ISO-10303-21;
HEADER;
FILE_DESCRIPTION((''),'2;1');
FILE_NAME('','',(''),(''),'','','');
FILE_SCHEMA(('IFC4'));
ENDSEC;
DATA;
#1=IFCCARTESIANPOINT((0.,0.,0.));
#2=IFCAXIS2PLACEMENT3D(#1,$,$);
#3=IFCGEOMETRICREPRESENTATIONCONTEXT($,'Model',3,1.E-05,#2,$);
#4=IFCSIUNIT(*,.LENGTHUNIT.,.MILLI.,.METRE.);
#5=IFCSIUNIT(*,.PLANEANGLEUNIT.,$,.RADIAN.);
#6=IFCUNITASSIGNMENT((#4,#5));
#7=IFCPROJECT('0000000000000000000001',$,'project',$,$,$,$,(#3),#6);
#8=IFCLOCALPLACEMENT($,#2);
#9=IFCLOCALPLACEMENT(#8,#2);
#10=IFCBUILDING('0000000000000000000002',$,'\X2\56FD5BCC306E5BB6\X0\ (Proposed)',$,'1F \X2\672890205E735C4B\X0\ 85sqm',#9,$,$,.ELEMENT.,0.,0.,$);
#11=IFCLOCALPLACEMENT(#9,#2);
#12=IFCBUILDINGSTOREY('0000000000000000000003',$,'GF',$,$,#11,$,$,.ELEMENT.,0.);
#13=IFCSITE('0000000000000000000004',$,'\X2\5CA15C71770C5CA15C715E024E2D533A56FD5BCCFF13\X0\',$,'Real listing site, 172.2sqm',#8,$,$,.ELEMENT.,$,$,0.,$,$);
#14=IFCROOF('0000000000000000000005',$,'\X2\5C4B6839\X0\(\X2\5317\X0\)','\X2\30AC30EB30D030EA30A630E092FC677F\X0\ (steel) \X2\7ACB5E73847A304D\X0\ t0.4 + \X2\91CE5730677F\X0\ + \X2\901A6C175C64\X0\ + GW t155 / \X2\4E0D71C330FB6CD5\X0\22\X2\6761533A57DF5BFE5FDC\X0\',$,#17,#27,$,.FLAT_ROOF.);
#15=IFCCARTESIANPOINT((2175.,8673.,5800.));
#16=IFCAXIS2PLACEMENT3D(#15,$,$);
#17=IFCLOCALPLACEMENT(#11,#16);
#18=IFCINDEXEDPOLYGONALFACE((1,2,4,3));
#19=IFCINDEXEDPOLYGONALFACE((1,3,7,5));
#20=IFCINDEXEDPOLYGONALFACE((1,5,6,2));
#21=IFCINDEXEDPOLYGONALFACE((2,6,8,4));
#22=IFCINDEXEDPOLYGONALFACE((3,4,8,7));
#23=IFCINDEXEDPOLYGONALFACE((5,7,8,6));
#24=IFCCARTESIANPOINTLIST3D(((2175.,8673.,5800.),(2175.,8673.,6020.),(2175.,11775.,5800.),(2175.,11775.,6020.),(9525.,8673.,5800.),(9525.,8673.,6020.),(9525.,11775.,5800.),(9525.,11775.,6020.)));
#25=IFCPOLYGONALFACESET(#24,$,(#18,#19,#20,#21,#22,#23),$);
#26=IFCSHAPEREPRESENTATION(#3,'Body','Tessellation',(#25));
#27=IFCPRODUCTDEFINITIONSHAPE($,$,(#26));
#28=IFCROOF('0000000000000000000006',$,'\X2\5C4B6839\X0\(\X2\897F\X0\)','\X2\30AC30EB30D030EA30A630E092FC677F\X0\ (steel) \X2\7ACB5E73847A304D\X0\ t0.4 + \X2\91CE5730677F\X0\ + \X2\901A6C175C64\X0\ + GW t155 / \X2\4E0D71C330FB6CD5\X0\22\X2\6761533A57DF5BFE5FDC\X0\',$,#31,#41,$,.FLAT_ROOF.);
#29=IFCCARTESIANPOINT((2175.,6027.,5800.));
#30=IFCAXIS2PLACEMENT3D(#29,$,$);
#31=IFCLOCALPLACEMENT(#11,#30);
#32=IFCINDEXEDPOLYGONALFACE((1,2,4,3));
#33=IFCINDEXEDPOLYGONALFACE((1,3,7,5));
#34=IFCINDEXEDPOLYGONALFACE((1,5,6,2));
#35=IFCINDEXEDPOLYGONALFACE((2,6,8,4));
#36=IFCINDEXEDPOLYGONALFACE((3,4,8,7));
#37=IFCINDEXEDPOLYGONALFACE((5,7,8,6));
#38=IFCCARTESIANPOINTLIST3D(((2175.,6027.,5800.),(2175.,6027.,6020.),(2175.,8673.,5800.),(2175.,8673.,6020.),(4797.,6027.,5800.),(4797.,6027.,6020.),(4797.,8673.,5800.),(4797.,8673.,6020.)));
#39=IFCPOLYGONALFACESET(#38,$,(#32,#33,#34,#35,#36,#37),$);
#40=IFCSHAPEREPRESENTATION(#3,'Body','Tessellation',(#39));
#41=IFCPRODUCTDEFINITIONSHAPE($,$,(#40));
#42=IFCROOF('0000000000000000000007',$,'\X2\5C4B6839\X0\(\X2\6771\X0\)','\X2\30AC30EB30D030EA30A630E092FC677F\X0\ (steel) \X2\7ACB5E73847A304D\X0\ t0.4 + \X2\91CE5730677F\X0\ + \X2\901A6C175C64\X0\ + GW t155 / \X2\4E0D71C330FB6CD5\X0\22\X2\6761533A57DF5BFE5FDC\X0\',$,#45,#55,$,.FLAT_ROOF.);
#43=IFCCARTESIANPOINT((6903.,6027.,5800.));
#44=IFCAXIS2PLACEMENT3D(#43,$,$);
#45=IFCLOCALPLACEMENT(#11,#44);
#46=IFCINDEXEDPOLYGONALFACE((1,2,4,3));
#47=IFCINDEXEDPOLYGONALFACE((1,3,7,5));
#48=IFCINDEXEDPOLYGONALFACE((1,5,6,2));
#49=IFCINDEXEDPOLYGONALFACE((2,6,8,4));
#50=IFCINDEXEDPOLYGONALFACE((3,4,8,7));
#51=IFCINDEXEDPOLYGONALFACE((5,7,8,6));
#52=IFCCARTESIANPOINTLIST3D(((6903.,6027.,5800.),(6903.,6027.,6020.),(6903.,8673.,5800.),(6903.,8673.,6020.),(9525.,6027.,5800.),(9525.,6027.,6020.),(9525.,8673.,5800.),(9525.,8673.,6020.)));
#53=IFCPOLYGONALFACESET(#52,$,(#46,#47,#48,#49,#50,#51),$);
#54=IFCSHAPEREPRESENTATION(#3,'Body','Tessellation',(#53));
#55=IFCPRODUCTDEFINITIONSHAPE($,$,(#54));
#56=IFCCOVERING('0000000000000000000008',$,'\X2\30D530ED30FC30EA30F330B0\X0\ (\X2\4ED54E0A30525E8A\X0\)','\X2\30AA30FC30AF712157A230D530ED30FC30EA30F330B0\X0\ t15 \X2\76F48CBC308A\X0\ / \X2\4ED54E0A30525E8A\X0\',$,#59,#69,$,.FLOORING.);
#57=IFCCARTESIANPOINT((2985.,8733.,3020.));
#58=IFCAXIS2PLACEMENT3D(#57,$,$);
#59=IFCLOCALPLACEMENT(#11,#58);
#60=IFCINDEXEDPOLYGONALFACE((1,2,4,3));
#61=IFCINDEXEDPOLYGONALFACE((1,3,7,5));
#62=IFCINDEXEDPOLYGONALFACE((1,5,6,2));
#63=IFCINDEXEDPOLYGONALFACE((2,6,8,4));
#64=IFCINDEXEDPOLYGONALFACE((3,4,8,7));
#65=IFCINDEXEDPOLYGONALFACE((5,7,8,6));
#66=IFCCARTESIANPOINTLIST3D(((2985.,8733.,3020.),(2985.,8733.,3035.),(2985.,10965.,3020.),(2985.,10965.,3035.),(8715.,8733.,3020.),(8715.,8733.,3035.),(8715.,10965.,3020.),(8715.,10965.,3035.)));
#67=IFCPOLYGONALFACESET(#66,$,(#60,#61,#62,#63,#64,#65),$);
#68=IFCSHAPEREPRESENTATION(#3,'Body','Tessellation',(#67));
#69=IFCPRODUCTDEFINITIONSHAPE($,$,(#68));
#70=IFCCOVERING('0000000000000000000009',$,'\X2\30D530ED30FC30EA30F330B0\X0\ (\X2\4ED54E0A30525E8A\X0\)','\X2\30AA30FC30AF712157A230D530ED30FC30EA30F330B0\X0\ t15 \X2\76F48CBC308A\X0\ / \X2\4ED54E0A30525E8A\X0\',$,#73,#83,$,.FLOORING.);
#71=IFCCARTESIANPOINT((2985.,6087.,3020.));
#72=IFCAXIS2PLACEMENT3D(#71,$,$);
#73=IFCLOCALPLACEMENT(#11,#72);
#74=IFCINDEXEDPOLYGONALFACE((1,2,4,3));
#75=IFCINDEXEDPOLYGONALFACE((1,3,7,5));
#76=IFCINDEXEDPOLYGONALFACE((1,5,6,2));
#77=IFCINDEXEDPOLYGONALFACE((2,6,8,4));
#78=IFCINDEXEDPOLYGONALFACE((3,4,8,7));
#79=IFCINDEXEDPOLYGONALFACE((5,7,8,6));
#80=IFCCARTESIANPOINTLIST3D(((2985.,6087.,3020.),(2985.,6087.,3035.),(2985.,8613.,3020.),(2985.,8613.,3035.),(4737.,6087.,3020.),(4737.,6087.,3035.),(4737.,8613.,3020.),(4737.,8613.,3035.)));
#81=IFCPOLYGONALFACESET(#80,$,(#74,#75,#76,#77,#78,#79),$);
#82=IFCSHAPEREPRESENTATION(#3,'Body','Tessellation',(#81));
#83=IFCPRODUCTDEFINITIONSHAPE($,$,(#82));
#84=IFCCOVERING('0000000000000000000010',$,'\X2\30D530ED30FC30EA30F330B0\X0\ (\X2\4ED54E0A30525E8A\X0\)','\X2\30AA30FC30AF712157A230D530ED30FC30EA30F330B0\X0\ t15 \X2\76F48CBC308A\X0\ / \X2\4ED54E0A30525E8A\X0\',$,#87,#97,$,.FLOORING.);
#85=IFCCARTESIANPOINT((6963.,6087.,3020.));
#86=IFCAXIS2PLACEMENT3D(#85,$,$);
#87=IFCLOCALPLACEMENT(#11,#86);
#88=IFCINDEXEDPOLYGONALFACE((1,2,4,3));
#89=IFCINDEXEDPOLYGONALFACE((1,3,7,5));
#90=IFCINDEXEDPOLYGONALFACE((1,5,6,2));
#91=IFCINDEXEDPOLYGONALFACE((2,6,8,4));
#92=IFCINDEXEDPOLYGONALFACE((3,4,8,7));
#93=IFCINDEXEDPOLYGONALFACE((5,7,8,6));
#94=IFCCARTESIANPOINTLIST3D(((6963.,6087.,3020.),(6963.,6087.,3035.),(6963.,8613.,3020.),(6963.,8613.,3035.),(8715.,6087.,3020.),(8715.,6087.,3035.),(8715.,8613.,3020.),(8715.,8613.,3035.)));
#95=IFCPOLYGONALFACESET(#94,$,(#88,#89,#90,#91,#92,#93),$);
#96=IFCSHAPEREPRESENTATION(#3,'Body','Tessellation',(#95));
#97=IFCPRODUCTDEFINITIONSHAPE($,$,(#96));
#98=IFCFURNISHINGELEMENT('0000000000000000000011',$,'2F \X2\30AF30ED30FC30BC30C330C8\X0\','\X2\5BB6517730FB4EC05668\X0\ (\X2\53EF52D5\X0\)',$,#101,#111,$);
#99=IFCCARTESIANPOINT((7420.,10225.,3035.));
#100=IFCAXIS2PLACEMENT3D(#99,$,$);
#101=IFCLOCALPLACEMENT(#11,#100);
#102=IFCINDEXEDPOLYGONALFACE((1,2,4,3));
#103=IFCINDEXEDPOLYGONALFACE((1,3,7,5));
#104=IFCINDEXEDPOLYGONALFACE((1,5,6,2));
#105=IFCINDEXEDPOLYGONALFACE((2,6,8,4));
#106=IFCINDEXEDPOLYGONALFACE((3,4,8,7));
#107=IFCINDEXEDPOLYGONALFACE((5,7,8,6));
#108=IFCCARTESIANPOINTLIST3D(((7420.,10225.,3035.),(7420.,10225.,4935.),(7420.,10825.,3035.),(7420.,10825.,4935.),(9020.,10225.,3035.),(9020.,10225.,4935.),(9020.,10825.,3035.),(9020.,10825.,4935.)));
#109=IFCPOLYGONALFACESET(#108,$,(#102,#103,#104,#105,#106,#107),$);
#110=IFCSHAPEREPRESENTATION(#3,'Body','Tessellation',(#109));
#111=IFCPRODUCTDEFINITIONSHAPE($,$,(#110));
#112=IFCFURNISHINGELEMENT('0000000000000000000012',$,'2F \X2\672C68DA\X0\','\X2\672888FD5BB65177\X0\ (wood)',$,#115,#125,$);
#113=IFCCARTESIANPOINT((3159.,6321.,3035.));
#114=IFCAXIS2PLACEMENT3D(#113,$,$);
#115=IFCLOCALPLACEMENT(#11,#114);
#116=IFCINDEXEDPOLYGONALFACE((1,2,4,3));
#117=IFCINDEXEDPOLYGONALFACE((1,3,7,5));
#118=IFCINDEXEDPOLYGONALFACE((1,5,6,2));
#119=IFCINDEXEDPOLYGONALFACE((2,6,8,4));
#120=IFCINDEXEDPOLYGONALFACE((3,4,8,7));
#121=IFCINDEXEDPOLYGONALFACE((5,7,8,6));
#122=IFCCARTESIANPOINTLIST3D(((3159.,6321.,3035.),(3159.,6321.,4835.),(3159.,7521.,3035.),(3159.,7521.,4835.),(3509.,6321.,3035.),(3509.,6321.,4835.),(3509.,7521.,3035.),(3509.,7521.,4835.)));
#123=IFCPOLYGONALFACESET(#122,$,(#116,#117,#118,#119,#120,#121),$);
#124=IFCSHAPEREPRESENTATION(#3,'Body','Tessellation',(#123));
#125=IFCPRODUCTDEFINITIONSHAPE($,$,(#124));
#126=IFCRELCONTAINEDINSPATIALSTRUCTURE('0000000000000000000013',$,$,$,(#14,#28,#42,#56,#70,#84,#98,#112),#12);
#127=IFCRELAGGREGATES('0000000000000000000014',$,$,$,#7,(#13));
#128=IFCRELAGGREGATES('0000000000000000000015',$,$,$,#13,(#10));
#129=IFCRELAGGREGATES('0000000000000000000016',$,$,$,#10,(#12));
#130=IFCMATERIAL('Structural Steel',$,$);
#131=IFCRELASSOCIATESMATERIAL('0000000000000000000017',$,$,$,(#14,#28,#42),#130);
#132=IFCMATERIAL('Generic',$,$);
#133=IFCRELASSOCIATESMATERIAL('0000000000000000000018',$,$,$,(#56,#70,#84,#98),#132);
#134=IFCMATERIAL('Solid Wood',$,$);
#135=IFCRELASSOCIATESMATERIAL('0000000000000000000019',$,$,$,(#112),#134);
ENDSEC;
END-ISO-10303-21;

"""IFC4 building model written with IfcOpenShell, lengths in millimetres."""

from ifc_helpers import new_model, si_unit, frame, frame_2d, origin, place, context, project, spatial, rectangle, extrude, material, element, save


model = new_model("IFC4")

# Units and contexts
model_context = context("Model", 3, precision=1e-05, world=origin())
ifc_project = project(units=[si_unit("LENGTHUNIT", "METRE", prefix="MILLI"), si_unit("PLANEANGLEUNIT", "RADIAN")], contexts=[model_context])

# Site, building, storey
site_placement = place(None, origin())
site = spatial("IfcSite", under=ifc_project, at=site_placement, Name="岡山県岡山市中区国富３", ObjectType="Real listing site, 172.2sqm", CompositionType="ELEMENT", RefElevation=0.0)
building_placement = place(site_placement, origin())
building = spatial("IfcBuilding", under=site, at=building_placement, Name="国富の家 (Proposed)", ObjectType="1F 木造平屋 85sqm", CompositionType="ELEMENT", ElevationOfRefHeight=0.0, ElevationOfTerrain=0.0)
storey_placement = place(building_placement, origin())
storey = spatial("IfcBuildingStorey", under=building, at=storey_placement, Name="GF", CompositionType="ELEMENT", Elevation=0.0)

# Shared definitions
ifc_material_1 = material(Name="Solid Wood")

# Shared definitions
ifc_material_2 = material(Name="Generic")

# Roofs
ifc_material_3 = material(Name="Structural Steel")
for number, where, name in (
    (1, (2175.0, 8673.0, 5800.0), "屋根(北)"),
):
    element("IfcRoof", number, at=place(storey_placement, frame(where)), inside=storey, material=ifc_material_3, Name=name, Description="ガルバリウム鋼板 (steel) 立平葺き t0.4 + 野地板 + 通気層 + GW t155 / 不燃・法22条区域対応", PredefinedType="FLAT_ROOF", context=model_context, shape_type="SweptSolid", body=[
        extrude(rectangle(XDim=7350.0, YDim=3102.0, at=frame_2d((3675.0, 1551.0))), frame((2175.0, 8673.0, 5800.0)), (0.0, 0.0, 1.0), 220.0),
    ])
roof_1_placement = place(storey_placement, frame((2175.0, 6027.0, 5800.0)))
element("IfcRoof", 2, at=roof_1_placement, inside=storey, material=ifc_material_3, Name="屋根(西)", Description="ガルバリウム鋼板 (steel) 立平葺き t0.4 + 野地板 + 通気層 + GW t155 / 不燃・法22条区域対応", PredefinedType="FLAT_ROOF", context=model_context, shape_type="SweptSolid", body=[
    extrude(rectangle(XDim=2622.0, YDim=2646.0, at=frame_2d((1311.0, 1323.0))), frame((2175.0, 6027.0, 5800.0)), (0.0, 0.0, 1.0), 220.0),
])
roof_2_placement = place(storey_placement, frame((6903.0, 6027.0, 5800.0)))
element("IfcRoof", 3, at=roof_2_placement, inside=storey, material=ifc_material_3, Name="屋根(東)", Description="ガルバリウム鋼板 (steel) 立平葺き t0.4 + 野地板 + 通気層 + GW t155 / 不燃・法22条区域対応", PredefinedType="FLAT_ROOF", context=model_context, shape_type="SweptSolid", body=[
    extrude(rectangle(XDim=2622.0, YDim=2646.0, at=frame_2d((1311.0, 1323.0))), frame((6903.0, 6027.0, 5800.0)), (0.0, 0.0, 1.0), 220.0),
])

# Coverings
covering_1_placement = place(storey_placement, frame((2985.0, 8733.0, 3020.0)))
element("IfcCovering", 4, at=covering_1_placement, inside=storey, material=ifc_material_2, Name="フローリング (仕上げ床)", Description="オーク無垢フローリング t15 直貼り / 仕上げ床", PredefinedType="FLOORING", context=model_context, shape_type="SweptSolid", body=[
    extrude(rectangle(XDim=5730.0, YDim=2232.0, at=frame_2d((2865.0, 1116.0))), frame((2985.0, 8733.0, 3020.0)), (0.0, 0.0, 1.0), 15.0),
])
covering_2_placement = place(storey_placement, frame((2985.0, 6087.0, 3020.0)))
element("IfcCovering", 5, at=covering_2_placement, inside=storey, material=ifc_material_2, Name="フローリング (仕上げ床)", Description="オーク無垢フローリング t15 直貼り / 仕上げ床", PredefinedType="FLOORING", context=model_context, shape_type="SweptSolid", body=[
    extrude(rectangle(XDim=1752.0, YDim=2526.0, at=frame_2d((876.0, 1263.0))), frame((2985.0, 6087.0, 3020.0)), (0.0, 0.0, 1.0), 15.0),
])
covering_3_placement = place(storey_placement, frame((6963.0, 6087.0, 3020.0)))
element("IfcCovering", 6, at=covering_3_placement, inside=storey, material=ifc_material_2, Name="フローリング (仕上げ床)", Description="オーク無垢フローリング t15 直貼り / 仕上げ床", PredefinedType="FLOORING", context=model_context, shape_type="SweptSolid", body=[
    extrude(rectangle(XDim=1752.0, YDim=2526.0, at=frame_2d((876.0, 1263.0))), frame((6963.0, 6087.0, 3020.0)), (0.0, 0.0, 1.0), 15.0),
])

# Furnishing elements
furnishing_1_placement = place(storey_placement, frame((7420.0, 10225.0, 3035.0)))
element("IfcFurnishingElement", 7, at=furnishing_1_placement, inside=storey, material=ifc_material_2, Name="2F クローゼット", Description="家具・什器 (可動)", context=model_context, shape_type="SweptSolid", body=[
    extrude(rectangle(XDim=1600.0, YDim=600.0, at=frame_2d((800.0, 300.0))), frame((7420.0, 10225.0, 3035.0)), (0.0, 0.0, 1.0), 1900.0),
])
furnishing_2_placement = place(storey_placement, frame((3159.0, 6321.0, 3035.0)))
element("IfcFurnishingElement", 8, at=furnishing_2_placement, inside=storey, material=ifc_material_1, Name="2F 本棚", Description="木製家具 (wood)", context=model_context, shape_type="SweptSolid", body=[
    extrude(rectangle(XDim=350.0, YDim=1200.0, at=frame_2d((175.0, 600.0))), frame((3159.0, 6321.0, 3035.0)), (0.0, 0.0, 1.0), 1800.0),
])

save(model, "model.ifc")
